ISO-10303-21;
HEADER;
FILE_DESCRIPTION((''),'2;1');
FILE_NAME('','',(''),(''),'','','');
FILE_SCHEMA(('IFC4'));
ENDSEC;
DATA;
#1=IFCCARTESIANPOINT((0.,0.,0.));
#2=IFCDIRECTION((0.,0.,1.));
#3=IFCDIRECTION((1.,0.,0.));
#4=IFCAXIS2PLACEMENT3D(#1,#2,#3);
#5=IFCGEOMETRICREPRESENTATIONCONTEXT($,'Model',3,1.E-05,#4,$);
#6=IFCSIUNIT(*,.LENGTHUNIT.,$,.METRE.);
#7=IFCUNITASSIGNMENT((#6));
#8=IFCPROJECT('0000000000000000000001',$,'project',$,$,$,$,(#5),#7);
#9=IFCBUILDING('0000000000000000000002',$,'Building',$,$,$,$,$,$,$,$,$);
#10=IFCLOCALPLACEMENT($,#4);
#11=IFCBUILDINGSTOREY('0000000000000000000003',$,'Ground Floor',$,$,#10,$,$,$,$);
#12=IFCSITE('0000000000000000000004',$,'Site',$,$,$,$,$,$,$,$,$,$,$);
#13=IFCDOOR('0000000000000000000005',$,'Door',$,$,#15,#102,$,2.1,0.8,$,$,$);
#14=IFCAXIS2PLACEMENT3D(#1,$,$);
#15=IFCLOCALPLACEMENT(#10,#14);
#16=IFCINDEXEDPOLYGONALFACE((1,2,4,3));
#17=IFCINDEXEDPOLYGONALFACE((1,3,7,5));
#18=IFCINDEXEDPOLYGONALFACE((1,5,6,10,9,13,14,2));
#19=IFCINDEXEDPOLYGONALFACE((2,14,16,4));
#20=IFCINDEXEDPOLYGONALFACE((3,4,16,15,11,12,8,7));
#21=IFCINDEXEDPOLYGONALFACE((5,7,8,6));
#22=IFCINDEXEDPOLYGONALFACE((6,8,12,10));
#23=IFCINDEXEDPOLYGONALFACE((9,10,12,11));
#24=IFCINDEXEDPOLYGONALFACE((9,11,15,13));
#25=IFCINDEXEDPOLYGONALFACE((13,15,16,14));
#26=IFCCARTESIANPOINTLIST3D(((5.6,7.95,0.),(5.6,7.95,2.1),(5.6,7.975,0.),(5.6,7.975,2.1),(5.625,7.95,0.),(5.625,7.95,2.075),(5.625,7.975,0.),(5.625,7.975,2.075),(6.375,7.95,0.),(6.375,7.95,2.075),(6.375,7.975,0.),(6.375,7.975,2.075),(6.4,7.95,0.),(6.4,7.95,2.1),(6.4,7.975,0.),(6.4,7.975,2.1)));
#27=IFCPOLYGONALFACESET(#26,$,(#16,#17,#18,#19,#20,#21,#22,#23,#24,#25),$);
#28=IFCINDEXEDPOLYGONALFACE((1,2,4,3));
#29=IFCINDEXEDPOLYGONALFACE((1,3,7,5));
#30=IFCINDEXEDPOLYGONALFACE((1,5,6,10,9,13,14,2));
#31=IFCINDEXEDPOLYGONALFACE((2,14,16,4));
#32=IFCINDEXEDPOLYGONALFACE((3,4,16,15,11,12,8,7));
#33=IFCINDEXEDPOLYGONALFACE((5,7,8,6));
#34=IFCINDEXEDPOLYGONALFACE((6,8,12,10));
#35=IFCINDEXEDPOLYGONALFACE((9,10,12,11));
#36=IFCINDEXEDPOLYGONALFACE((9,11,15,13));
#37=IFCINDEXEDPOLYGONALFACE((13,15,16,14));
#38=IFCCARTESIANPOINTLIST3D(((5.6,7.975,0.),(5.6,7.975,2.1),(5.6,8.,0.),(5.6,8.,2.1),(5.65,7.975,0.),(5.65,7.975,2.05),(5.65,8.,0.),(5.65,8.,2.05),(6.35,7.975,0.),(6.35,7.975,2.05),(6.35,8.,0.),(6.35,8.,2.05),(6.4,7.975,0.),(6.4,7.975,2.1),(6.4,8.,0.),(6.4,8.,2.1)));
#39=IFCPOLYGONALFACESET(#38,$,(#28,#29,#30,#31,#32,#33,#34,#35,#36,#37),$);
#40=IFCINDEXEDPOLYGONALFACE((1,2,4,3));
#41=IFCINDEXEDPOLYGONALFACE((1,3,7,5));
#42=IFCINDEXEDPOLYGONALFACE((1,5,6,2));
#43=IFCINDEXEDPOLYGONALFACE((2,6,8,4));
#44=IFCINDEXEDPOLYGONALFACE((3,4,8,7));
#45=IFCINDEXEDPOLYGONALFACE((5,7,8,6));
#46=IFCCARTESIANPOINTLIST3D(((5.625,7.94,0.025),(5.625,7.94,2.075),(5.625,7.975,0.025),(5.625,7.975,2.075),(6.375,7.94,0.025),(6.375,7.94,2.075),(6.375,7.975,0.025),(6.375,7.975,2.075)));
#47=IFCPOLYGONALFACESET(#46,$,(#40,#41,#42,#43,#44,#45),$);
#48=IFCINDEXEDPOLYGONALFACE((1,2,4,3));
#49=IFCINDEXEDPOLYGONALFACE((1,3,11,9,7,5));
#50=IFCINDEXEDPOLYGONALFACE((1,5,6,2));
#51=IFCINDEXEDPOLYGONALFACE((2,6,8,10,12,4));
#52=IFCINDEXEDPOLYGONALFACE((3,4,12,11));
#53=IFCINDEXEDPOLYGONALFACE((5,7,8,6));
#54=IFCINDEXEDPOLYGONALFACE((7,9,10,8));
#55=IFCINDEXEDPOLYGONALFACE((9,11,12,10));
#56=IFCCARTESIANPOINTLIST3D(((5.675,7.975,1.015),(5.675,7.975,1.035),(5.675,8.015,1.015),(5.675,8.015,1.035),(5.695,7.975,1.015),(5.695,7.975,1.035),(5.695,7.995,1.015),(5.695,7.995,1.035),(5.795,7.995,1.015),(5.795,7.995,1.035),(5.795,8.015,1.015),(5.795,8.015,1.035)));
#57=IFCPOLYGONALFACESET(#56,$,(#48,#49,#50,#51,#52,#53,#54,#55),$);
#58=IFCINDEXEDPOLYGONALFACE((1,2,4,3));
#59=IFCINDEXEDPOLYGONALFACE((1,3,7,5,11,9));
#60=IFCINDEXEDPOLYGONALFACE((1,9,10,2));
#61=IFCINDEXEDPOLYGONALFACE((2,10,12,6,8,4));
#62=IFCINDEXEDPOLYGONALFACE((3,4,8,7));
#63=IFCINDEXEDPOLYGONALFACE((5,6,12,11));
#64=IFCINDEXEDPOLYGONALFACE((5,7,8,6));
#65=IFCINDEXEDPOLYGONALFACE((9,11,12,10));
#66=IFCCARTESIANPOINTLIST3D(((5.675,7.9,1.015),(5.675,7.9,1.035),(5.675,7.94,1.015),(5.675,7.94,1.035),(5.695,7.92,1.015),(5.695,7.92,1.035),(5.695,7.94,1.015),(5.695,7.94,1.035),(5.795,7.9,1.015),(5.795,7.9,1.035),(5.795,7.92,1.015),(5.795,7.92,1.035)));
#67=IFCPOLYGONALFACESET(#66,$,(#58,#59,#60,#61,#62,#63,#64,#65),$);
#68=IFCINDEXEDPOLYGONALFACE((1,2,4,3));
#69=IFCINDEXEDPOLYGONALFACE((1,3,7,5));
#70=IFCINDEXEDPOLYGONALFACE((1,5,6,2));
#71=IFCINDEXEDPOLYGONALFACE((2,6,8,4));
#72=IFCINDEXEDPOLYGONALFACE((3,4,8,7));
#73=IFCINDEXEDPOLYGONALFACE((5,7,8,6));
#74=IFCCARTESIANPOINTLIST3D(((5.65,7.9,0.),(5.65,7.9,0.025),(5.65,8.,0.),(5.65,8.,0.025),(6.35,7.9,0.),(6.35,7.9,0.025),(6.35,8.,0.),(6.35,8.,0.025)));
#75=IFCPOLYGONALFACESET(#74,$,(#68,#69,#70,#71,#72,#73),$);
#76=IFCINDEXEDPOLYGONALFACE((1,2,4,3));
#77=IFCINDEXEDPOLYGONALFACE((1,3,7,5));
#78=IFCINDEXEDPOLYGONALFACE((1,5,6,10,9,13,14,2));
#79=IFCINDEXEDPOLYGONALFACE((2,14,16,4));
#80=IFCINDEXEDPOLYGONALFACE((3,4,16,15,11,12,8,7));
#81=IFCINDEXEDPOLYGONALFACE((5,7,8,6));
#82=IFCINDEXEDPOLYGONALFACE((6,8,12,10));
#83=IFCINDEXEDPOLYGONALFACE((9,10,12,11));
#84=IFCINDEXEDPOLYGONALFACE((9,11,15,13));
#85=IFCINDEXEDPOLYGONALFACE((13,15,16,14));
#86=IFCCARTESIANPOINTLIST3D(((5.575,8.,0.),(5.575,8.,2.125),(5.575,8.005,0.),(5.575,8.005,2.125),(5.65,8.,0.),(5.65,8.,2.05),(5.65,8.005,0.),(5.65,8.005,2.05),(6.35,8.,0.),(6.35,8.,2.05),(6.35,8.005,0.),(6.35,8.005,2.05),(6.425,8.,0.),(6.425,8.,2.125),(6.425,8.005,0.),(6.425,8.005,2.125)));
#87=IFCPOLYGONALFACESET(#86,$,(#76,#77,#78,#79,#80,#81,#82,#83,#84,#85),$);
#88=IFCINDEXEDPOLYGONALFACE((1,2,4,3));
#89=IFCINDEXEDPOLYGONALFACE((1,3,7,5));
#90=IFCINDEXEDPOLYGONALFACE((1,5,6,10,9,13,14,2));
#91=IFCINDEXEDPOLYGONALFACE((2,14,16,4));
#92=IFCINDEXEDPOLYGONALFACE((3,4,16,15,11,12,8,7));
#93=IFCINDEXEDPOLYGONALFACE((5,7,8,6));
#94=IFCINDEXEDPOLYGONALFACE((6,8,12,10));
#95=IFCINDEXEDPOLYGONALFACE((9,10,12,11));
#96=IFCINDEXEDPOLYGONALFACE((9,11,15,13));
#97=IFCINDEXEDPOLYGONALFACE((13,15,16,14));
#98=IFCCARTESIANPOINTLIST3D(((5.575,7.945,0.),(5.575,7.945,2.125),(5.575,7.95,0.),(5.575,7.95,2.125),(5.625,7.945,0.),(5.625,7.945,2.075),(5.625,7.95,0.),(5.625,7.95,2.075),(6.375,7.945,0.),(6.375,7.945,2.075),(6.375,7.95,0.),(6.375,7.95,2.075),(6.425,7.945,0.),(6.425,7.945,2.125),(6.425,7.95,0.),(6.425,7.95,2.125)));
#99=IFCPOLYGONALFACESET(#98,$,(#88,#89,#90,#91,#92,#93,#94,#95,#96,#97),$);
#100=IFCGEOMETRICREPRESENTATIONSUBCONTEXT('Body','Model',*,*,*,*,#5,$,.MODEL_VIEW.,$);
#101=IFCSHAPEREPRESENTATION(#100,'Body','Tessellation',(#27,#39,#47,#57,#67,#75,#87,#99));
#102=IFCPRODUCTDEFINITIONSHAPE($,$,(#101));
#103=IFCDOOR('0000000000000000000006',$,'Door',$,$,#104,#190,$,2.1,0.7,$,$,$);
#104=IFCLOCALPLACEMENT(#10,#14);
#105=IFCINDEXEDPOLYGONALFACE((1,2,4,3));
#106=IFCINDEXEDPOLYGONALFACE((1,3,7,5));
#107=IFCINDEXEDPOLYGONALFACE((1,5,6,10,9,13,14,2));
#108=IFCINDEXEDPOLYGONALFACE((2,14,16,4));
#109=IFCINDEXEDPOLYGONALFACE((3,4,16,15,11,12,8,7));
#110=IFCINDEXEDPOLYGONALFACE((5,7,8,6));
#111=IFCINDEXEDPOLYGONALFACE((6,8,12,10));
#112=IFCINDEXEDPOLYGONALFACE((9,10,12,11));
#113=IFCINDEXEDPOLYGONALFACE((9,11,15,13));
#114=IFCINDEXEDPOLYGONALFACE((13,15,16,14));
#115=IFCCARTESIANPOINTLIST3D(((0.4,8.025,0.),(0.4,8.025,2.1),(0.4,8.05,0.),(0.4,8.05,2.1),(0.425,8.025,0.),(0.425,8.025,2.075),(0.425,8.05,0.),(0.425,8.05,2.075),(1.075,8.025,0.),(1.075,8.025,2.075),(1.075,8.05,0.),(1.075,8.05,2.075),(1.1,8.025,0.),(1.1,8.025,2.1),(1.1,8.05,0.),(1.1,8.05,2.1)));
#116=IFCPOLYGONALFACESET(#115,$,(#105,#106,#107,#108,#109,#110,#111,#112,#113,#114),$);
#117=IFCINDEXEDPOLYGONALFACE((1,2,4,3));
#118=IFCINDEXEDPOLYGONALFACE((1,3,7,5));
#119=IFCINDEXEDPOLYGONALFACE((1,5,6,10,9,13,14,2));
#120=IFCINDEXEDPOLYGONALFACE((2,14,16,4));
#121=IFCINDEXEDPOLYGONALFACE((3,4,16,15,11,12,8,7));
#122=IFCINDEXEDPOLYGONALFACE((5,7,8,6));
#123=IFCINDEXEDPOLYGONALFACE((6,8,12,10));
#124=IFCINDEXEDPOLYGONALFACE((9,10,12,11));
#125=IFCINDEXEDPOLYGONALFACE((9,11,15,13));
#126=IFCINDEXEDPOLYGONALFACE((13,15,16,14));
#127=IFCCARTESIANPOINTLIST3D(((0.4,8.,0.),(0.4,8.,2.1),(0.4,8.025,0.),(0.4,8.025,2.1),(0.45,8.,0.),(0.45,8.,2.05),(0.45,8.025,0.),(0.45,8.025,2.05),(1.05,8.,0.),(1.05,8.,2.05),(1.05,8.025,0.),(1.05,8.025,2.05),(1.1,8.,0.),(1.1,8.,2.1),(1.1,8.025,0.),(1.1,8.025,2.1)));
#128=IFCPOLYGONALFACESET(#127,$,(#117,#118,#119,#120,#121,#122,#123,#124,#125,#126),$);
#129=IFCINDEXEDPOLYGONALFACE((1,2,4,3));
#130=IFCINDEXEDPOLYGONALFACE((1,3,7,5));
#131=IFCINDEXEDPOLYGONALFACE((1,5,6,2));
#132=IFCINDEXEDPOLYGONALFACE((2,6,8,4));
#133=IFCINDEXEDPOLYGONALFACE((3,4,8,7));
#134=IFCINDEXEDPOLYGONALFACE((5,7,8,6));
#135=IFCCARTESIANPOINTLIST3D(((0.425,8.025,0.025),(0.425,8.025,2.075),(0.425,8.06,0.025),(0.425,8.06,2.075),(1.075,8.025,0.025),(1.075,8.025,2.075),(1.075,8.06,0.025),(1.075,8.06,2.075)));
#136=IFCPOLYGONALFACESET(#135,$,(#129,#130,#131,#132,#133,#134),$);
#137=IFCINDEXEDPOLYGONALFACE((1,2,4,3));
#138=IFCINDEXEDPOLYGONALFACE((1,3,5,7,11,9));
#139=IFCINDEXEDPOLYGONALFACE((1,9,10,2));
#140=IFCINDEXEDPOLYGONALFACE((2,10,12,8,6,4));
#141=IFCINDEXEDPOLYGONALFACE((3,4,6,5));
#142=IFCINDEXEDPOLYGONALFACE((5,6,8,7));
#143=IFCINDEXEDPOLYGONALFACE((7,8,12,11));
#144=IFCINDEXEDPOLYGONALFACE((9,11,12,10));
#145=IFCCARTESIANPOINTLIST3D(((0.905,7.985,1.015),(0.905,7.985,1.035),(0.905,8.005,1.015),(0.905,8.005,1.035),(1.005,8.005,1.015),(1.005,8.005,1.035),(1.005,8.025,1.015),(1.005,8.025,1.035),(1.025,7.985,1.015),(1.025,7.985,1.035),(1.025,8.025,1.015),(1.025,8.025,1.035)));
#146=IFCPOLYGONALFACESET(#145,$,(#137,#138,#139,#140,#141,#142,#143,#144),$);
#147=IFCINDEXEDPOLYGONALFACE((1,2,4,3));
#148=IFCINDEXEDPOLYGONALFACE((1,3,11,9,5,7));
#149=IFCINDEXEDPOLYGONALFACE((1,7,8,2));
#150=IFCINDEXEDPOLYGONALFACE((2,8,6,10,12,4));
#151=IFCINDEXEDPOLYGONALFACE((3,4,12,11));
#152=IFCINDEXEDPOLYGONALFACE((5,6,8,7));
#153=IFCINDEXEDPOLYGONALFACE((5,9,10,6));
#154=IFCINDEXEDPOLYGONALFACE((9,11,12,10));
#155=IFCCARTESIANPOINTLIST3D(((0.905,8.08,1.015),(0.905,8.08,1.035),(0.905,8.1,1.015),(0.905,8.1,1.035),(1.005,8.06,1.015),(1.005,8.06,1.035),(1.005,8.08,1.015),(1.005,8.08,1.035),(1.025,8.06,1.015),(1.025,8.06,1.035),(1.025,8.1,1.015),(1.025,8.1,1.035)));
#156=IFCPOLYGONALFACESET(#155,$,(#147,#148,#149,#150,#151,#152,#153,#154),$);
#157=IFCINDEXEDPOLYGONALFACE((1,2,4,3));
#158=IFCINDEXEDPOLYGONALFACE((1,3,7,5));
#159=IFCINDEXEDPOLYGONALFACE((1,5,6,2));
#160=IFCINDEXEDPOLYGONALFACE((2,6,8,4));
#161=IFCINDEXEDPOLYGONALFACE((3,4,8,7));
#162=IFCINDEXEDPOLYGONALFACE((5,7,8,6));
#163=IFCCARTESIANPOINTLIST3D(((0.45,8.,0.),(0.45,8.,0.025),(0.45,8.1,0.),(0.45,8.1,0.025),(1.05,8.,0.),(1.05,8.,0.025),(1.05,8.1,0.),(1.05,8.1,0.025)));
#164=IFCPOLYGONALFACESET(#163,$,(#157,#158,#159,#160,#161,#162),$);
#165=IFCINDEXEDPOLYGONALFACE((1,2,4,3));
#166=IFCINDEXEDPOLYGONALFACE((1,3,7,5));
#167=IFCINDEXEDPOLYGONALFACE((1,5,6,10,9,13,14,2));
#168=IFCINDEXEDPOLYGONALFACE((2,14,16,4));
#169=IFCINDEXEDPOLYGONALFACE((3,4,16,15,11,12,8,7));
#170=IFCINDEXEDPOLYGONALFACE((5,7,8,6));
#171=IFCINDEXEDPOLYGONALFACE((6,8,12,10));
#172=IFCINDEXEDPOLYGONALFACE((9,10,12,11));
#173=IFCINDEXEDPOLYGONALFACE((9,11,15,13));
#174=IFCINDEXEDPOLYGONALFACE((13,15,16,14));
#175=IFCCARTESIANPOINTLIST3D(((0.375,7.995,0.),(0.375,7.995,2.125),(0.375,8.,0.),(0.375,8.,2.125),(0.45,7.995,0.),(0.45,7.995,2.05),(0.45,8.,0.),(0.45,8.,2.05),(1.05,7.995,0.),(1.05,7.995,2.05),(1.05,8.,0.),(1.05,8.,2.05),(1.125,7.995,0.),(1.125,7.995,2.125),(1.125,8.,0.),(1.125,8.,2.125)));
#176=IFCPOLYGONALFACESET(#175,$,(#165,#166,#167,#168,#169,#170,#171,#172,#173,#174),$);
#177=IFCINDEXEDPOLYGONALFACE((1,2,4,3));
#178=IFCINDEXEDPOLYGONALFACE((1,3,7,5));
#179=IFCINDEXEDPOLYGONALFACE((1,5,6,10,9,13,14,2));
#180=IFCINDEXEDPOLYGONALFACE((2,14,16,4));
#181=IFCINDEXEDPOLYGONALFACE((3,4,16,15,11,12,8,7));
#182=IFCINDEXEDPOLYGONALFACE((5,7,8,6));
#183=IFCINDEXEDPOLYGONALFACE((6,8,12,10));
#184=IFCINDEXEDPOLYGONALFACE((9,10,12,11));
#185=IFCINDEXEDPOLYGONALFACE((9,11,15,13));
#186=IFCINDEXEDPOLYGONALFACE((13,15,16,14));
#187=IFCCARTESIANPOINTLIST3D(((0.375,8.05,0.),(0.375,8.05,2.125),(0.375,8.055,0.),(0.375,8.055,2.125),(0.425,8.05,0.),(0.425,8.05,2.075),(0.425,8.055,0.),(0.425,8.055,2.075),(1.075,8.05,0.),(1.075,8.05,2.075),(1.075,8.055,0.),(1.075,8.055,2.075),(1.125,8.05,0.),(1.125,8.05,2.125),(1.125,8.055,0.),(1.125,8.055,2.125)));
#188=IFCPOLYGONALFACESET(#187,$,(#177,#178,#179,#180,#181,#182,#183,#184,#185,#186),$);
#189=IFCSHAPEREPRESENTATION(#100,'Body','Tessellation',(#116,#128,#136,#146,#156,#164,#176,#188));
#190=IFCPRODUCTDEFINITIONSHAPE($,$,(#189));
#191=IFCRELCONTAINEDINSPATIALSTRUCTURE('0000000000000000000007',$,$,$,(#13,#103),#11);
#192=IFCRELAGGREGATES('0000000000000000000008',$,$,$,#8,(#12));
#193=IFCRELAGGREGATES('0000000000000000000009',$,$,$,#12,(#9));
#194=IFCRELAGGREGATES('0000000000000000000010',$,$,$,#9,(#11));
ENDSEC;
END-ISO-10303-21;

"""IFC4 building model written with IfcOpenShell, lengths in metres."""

from ifc_helpers import new_model, si_unit, frame, origin_with_axes, place, context, subcontext, project, spatial, line, indexed_curve, outline, extrude, element, save


model = new_model("IFC4")

# Units and contexts
model_context = context("Model", 3, precision=1e-05, world=origin_with_axes())
body_context = subcontext(model_context, "Body", "Model", "MODEL_VIEW")
ifc_project = project(units=[si_unit("LENGTHUNIT", "METRE")], contexts=[model_context])

# Site, building, storey
site = spatial("IfcSite", under=ifc_project, Name="Site")
building = spatial("IfcBuilding", under=site, Name="Building")
storey_placement = place(None, origin_with_axes())
storey = spatial("IfcBuildingStorey", under=building, at=storey_placement, Name="Ground Floor")

# Doors
door_1_placement = place(storey_placement, frame((6.4, 8.0, 0.0), z_axis=(0.0, 0.0, 1.0), x_axis=(-1.0, 0.0, 0.0)))
element("IfcDoor", 1, at=door_1_placement, inside=storey, Name="Door", OverallHeight=2.1, OverallWidth=0.8, context=body_context, shape_type="SweptSolid", body=[
    extrude(outline(indexed_curve([(0.0, 0.0), (0.0, 2.1), (0.8, 2.1), (0.8, 0.0), (0.775, 0.0), (0.775, 2.075), (0.025, 2.075), (0.025, 0.0)], segments=[line(1, 2, 3, 4, 5, 6, 7, 8, 1)])), frame((0.0, 0.025, 0.0), z_axis=(0.0, -1.0, 0.0), x_axis=(1.0, 0.0, 0.0)), (0.0, 0.0, -1.0), 0.025),
    extrude(outline(indexed_curve([(0.0, 0.0), (0.0, 2.1), (0.8, 2.1), (0.8, 0.0), (0.75, 0.0), (0.75, 2.05), (0.05, 2.05), (0.05, 0.0)], segments=[line(1, 2, 3, 4, 5, 6, 7, 8, 1)])), frame((0.0, 0.0, 0.0), z_axis=(0.0, -1.0, 0.0), x_axis=(1.0, 0.0, 0.0)), (0.0, 0.0, -1.0), 0.025),
    extrude(outline(indexed_curve([(0.0, 0.0), (0.75, 0.0), (0.75, 0.035), (0.0, 0.035)], segments=[line(1, 2, 3, 4, 1)])), frame((0.025, 0.025, 0.025), z_axis=(0.0, 0.0, 1.0), x_axis=(1.0, 0.0, 0.0)), (0.0, 0.0, 1.0), 2.05),
    extrude(outline(indexed_curve([(0.0, 0.0), (0.0, -0.04), (-0.12, -0.04), (-0.12, -0.02), (-0.02, -0.02), (-0.02, 0.0)], segments=[line(1, 2, 3, 4, 5, 6, 1)])), frame((0.725, 0.025, 1.015), z_axis=(0.0, 0.0, 1.0), x_axis=(1.0, 0.0, 0.0)), (0.0, 0.0, 1.0), 0.02),
    extrude(outline(indexed_curve([(0.0, 0.0), (0.0, 0.04), (-0.12, 0.04), (-0.12, 0.02), (-0.02, 0.02), (-0.02, 0.0)], segments=[line(1, 2, 3, 4, 5, 6, 1)])), frame((0.725, 0.06, 1.015), z_axis=(0.0, 0.0, 1.0), x_axis=(1.0, 0.0, 0.0)), (0.0, 0.0, 1.0), 0.02),
    extrude(outline(indexed_curve([(0.0, 0.0), (0.7, 0.0), (0.7, 0.1), (0.0, 0.1)], segments=[line(1, 2, 3, 4, 1)])), frame((0.05, 0.0, 0.0), z_axis=(0.0, 0.0, 1.0), x_axis=(1.0, 0.0, 0.0)), (0.0, 0.0, 1.0), 0.025),
    extrude(outline(indexed_curve([(0.0, 0.0), (0.0, 2.125), (0.85, 2.125), (0.85, 0.0), (0.775, 0.0), (0.775, 2.05), (0.075, 2.05), (0.075, 0.0)], segments=[line(1, 2, 3, 4, 5, 6, 7, 8, 1)])), frame((-0.025, -0.005, 0.0), z_axis=(0.0, -1.0, 0.0), x_axis=(1.0, 0.0, 0.0)), (0.0, 0.0, -1.0), 0.005),
    extrude(outline(indexed_curve([(0.0, 0.0), (0.0, 2.125), (0.85, 2.125), (0.85, 0.0), (0.8, 0.0), (0.8, 2.075), (0.05, 2.075), (0.05, 0.0)], segments=[line(1, 2, 3, 4, 5, 6, 7, 8, 1)])), frame((-0.025, 0.05, 0.0), z_axis=(0.0, -1.0, 0.0), x_axis=(1.0, 0.0, 0.0)), (0.0, 0.0, -1.0), 0.005),
])
door_2_placement = place(storey_placement, frame((0.4, 8.0, 0.0), z_axis=(0.0, 0.0, 1.0), x_axis=(1.0, 0.0, 0.0)))
element("IfcDoor", 2, at=door_2_placement, inside=storey, Name="Door", OverallHeight=2.1, OverallWidth=0.7, context=body_context, shape_type="SweptSolid", body=[
    extrude(outline(indexed_curve([(0.0, 0.0), (0.0, 2.1), (0.7, 2.1), (0.7, 0.0), (0.675, 0.0), (0.675, 2.075), (0.025, 2.075), (0.025, 0.0)], segments=[line(1, 2, 3, 4, 5, 6, 7, 8, 1)])), frame((0.0, 0.025, 0.0), z_axis=(0.0, -1.0, 0.0), x_axis=(1.0, 0.0, 0.0)), (0.0, 0.0, -1.0), 0.025),
    extrude(outline(indexed_curve([(0.0, 0.0), (0.0, 2.1), (0.7, 2.1), (0.7, 0.0), (0.65, 0.0), (0.65, 2.05), (0.05, 2.05), (0.05, 0.0)], segments=[line(1, 2, 3, 4, 5, 6, 7, 8, 1)])), frame((0.0, 0.0, 0.0), z_axis=(0.0, -1.0, 0.0), x_axis=(1.0, 0.0, 0.0)), (0.0, 0.0, -1.0), 0.025),
    extrude(outline(indexed_curve([(0.0, 0.0), (0.65, 0.0), (0.65, 0.035), (0.0, 0.035)], segments=[line(1, 2, 3, 4, 1)])), frame((0.025, 0.025, 0.025), z_axis=(0.0, 0.0, 1.0), x_axis=(1.0, 0.0, 0.0)), (0.0, 0.0, 1.0), 2.05),
    extrude(outline(indexed_curve([(0.0, 0.0), (0.0, -0.04), (-0.12, -0.04), (-0.12, -0.02), (-0.02, -0.02), (-0.02, 0.0)], segments=[line(1, 2, 3, 4, 5, 6, 1)])), frame((0.625, 0.025, 1.015), z_axis=(0.0, 0.0, 1.0), x_axis=(1.0, 0.0, 0.0)), (0.0, 0.0, 1.0), 0.02),
    extrude(outline(indexed_curve([(0.0, 0.0), (0.0, 0.04), (-0.12, 0.04), (-0.12, 0.02), (-0.02, 0.02), (-0.02, 0.0)], segments=[line(1, 2, 3, 4, 5, 6, 1)])), frame((0.625, 0.06, 1.015), z_axis=(0.0, 0.0, 1.0), x_axis=(1.0, 0.0, 0.0)), (0.0, 0.0, 1.0), 0.02),
    extrude(outline(indexed_curve([(0.0, 0.0), (0.6, 0.0), (0.6, 0.1), (0.0, 0.1)], segments=[line(1, 2, 3, 4, 1)])), frame((0.05, 0.0, 0.0), z_axis=(0.0, 0.0, 1.0), x_axis=(1.0, 0.0, 0.0)), (0.0, 0.0, 1.0), 0.025),
    extrude(outline(indexed_curve([(0.0, 0.0), (0.0, 2.125), (0.75, 2.125), (0.75, 0.0), (0.675, 0.0), (0.675, 2.05), (0.075, 2.05), (0.075, 0.0)], segments=[line(1, 2, 3, 4, 5, 6, 7, 8, 1)])), frame((-0.025, -0.005, 0.0), z_axis=(0.0, -1.0, 0.0), x_axis=(1.0, 0.0, 0.0)), (0.0, 0.0, -1.0), 0.005),
    extrude(outline(indexed_curve([(0.0, 0.0), (0.0, 2.125), (0.75, 2.125), (0.75, 0.0), (0.7, 0.0), (0.7, 2.075), (0.05, 2.075), (0.05, 0.0)], segments=[line(1, 2, 3, 4, 5, 6, 7, 8, 1)])), frame((-0.025, 0.05, 0.0), z_axis=(0.0, -1.0, 0.0), x_axis=(1.0, 0.0, 0.0)), (0.0, 0.0, -1.0), 0.005),
])

save(model, "model.ifc")
